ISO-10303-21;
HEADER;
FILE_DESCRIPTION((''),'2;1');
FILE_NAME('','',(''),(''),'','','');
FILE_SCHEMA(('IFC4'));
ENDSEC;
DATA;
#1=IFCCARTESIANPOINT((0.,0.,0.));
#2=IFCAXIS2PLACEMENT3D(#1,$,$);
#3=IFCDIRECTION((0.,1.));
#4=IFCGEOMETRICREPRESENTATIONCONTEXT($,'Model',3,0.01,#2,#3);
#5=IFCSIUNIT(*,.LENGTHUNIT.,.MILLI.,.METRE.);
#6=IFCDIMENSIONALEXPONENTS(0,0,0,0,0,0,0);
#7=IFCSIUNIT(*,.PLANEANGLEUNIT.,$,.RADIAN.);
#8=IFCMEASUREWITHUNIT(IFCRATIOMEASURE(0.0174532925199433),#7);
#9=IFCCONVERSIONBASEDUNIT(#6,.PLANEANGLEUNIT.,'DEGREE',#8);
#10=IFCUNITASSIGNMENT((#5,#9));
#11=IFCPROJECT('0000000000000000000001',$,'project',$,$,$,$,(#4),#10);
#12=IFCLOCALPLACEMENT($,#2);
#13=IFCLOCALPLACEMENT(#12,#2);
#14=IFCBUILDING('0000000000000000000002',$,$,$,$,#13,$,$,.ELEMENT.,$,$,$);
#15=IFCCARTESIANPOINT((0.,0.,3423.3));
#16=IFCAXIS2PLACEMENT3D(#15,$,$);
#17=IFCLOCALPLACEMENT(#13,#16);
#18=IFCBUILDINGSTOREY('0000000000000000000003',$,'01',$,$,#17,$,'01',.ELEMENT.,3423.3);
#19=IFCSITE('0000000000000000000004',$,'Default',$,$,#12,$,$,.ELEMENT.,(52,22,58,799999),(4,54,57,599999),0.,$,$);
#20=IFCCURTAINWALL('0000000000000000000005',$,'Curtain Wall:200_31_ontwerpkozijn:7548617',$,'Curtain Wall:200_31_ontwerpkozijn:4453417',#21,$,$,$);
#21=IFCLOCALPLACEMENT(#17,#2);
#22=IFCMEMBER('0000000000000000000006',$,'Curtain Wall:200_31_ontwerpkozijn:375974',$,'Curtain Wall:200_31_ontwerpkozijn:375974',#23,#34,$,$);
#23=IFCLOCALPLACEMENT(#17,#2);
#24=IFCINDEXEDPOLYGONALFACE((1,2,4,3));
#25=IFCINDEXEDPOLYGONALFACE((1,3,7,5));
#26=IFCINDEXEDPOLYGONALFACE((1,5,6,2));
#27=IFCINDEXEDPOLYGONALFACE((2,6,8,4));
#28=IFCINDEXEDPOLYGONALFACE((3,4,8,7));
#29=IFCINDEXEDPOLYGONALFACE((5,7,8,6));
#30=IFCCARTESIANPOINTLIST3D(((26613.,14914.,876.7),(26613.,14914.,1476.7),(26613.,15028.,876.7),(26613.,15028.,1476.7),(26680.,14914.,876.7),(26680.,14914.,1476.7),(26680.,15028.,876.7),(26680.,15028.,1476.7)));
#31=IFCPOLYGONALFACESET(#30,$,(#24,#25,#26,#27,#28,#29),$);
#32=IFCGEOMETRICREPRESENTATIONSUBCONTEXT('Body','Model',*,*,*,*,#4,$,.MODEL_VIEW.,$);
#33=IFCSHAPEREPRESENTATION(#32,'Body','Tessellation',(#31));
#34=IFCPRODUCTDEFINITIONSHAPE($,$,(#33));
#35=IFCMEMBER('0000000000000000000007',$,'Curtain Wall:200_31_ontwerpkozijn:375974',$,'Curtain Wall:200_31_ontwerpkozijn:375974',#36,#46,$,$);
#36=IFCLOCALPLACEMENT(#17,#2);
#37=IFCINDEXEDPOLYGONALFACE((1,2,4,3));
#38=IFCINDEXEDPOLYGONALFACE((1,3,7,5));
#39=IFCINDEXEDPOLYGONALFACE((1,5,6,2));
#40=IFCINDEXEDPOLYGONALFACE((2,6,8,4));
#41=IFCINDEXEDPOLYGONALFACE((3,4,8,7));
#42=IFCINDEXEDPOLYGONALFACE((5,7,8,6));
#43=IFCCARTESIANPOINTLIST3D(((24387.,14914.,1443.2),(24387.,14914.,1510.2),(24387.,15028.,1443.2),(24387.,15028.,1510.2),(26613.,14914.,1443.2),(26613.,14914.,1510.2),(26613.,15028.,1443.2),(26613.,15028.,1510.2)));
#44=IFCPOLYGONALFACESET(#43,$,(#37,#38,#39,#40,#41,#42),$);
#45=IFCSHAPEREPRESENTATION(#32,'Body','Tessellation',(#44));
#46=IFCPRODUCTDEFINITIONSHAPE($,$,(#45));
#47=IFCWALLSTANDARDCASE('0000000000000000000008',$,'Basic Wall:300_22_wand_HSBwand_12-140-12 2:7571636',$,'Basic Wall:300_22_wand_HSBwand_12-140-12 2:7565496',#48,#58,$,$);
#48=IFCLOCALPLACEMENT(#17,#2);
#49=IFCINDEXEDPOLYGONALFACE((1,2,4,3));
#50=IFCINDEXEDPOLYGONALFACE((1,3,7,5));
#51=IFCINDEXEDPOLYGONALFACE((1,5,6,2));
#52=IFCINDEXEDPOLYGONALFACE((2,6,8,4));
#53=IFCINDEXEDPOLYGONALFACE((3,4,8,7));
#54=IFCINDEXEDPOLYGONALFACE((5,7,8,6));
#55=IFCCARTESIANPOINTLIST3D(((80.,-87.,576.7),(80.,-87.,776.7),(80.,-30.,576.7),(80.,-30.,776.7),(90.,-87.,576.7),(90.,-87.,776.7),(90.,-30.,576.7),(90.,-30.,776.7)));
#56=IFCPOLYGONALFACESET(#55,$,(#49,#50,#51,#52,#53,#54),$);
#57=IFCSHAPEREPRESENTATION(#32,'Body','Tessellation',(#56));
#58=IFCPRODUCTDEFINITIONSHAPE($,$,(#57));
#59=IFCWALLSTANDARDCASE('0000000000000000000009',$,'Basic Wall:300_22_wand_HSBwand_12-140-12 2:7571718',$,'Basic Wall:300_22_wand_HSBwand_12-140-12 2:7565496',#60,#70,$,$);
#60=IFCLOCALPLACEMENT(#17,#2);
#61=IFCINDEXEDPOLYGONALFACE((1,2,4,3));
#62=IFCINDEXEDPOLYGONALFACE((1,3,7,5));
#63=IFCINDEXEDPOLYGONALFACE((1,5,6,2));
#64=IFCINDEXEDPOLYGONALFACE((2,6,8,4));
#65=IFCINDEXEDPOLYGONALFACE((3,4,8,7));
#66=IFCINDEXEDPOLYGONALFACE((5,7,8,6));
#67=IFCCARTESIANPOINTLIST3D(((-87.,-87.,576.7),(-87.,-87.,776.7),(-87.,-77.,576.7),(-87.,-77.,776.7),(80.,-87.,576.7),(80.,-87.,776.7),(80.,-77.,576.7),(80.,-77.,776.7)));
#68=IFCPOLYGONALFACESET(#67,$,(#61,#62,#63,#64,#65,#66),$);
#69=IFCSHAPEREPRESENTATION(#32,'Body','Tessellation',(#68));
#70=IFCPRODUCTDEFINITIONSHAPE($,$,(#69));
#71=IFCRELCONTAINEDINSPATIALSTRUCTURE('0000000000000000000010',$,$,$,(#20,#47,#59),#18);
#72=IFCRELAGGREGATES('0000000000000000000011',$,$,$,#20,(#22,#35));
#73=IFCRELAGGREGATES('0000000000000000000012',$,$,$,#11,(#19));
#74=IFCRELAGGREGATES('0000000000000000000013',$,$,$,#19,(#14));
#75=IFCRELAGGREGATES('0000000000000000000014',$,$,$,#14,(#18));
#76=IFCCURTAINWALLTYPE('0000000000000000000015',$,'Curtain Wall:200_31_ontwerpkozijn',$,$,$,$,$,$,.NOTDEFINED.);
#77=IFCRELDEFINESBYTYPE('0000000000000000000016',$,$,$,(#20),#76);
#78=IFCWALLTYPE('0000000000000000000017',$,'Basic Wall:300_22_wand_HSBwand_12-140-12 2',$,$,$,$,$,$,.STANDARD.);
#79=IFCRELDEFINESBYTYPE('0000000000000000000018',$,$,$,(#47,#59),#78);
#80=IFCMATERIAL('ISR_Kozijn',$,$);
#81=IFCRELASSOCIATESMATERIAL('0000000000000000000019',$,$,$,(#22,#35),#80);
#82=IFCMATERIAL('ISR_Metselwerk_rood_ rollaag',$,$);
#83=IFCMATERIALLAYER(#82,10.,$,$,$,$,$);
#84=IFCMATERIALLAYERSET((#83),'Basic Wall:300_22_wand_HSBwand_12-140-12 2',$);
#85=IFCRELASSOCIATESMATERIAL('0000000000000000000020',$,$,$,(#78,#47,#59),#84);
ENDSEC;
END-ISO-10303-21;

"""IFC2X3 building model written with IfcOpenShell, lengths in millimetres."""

from ifc_helpers import new_model, entity, si_unit, converted_unit, direction, frame, frame_2d, origin, origin_2d_with_axis, place, context, subcontext, project, spatial, rectangle, extrude, material, layer, layer_set, layer_usage, type_object, element, aggregate, save


model = new_model("IFC2X3")

# Units and contexts
model_context = context("Model", 3, precision=0.01, world=origin(), true_north=direction((0.0, 1.0)))
body_context = subcontext(model_context, "Body", "Model", "MODEL_VIEW")
ifc_project = project(units=[si_unit("LENGTHUNIT", "METRE", prefix="MILLI"), converted_unit("PLANEANGLEUNIT", "DEGREE", entity("IfcRatioMeasure", 0.0174532925199433), si_unit("PLANEANGLEUNIT", "RADIAN"), dimensions=[0, 0, 0, 0, 0, 0, 0])], contexts=[model_context])

# Site, building, storey
site_placement = place(None, origin())
site = spatial("IfcSite", under=ifc_project, at=site_placement, Name="Default", CompositionType="ELEMENT", RefLatitude=(52, 22, 58, 799999), RefLongitude=(4, 54, 57, 599999), RefElevation=0.0)
building_placement = place(site_placement, origin())
building = spatial("IfcBuilding", under=site, at=building_placement, CompositionType="ELEMENT")
storey_placement = place(building_placement, frame((0.0, 0.0, 3423.3)))
storey = spatial("IfcBuildingStorey", under=building, at=storey_placement, Name="01", LongName="01", CompositionType="ELEMENT", Elevation=3423.3)

# Curtain wall, members
curtain_wall_type = type_object("IfcCurtainWallType", Name="Curtain Wall:200_31_ontwerpkozijn", PredefinedType="NOTDEFINED")
ifc_material_1 = material(Name="ISR_Kozijn")
curtain_wall_1_placement = place(storey_placement, frame((0.0, 0.0, -3423.3)))
curtain_wall_1 = element("IfcCurtainWall", 1, at=curtain_wall_1_placement, inside=storey, type_object=curtain_wall_type, Name="Curtain Wall:200_31_ontwerpkozijn:7548617", ObjectType="Curtain Wall:200_31_ontwerpkozijn:4453417")
member_1_placement = place(curtain_wall_1_placement, frame((0.0, 0.0, 3423.3)))
member_1 = element("IfcMember", 2, at=member_1_placement, material=ifc_material_1, Name="Curtain Wall:200_31_ontwerpkozijn:375974", ObjectType="Curtain Wall:200_31_ontwerpkozijn:375974", context=body_context, shape_type="SweptSolid", body=[
    extrude(rectangle(XDim=67.0, YDim=114.0, at=origin_2d_with_axis()), frame((26646.5, 14971.0, 1476.7), z_axis=(0.0, 0.0, -1.0), x_axis=(-1.0, 0.0, 0.0)), (0.0, 0.0, 1.0), 600.0),
])
member_2_placement = place(curtain_wall_1_placement, frame((0.0, 0.0, 3423.3)))
member_2 = element("IfcMember", 3, at=member_2_placement, material=ifc_material_1, Name="Curtain Wall:200_31_ontwerpkozijn:375974", ObjectType="Curtain Wall:200_31_ontwerpkozijn:375974", context=body_context, shape_type="SweptSolid", body=[
    extrude(rectangle(XDim=67.0, YDim=114.0, at=frame_2d((0.0, 0.0), x_axis=(1.0, 0.0))), frame((24387.0, 14971.0, 1476.7), z_axis=(1.0, 0.0, 0.0), x_axis=(0.0, 0.0, -1.0)), (0.0, 0.0, 1.0), 2226.0),
])
aggregate(curtain_wall_1, [member_1, member_2])

# Walls
ifc_material_2 = material(Name="ISR_Metselwerk_rood_ rollaag")
ifc_layer = layer(ifc_material_2, 10.0)
ifc_layer_set = layer_set([ifc_layer], Name="Basic Wall:300_22_wand_HSBwand_12-140-12 2")
ifc_layer_usage_1 = layer_usage(ifc_layer_set, "AXIS2", "NEGATIVE", 5.0)
wall_type = type_object("IfcWallType", Name="Basic Wall:300_22_wand_HSBwand_12-140-12 2", PredefinedType="STANDARD", material=ifc_layer_set)
wall_1_placement = place(storey_placement, frame((85.0, -30.0, 576.7), z_axis=(0.0, 0.0, 1.0), x_axis=(0.0, -1.0, 0.0)))
element("IfcWallStandardCase", 4, at=wall_1_placement, inside=storey, type_object=wall_type, material=ifc_layer_usage_1, Name="Basic Wall:300_22_wand_HSBwand_12-140-12 2:7571636", ObjectType="Basic Wall:300_22_wand_HSBwand_12-140-12 2:7565496", context=body_context, shape_type="SweptSolid", body=[
    extrude(rectangle(XDim=57.0, YDim=10.0, at=frame_2d((28.5, 0.0), x_axis=(-1.0, 0.0))), origin(), (0.0, 0.0, 1.0), 200.0),
])
ifc_layer_usage_2 = layer_usage(ifc_layer_set, "AXIS2", "NEGATIVE", 5.0)
wall_2_placement = place(storey_placement, frame((80.0, -82.0, 576.7), z_axis=(0.0, 0.0, 1.0), x_axis=(-1.0, 0.0, 0.0)))
element("IfcWallStandardCase", 5, at=wall_2_placement, inside=storey, type_object=wall_type, material=ifc_layer_usage_2, Name="Basic Wall:300_22_wand_HSBwand_12-140-12 2:7571718", ObjectType="Basic Wall:300_22_wand_HSBwand_12-140-12 2:7565496", context=body_context, shape_type="SweptSolid", body=[
    extrude(rectangle(XDim=167.0, YDim=10.0, at=frame_2d((83.5, 0.0), x_axis=(-1.0, 0.0))), origin(), (0.0, 0.0, 1.0), 200.0),
])

save(model, "model.ifc")
